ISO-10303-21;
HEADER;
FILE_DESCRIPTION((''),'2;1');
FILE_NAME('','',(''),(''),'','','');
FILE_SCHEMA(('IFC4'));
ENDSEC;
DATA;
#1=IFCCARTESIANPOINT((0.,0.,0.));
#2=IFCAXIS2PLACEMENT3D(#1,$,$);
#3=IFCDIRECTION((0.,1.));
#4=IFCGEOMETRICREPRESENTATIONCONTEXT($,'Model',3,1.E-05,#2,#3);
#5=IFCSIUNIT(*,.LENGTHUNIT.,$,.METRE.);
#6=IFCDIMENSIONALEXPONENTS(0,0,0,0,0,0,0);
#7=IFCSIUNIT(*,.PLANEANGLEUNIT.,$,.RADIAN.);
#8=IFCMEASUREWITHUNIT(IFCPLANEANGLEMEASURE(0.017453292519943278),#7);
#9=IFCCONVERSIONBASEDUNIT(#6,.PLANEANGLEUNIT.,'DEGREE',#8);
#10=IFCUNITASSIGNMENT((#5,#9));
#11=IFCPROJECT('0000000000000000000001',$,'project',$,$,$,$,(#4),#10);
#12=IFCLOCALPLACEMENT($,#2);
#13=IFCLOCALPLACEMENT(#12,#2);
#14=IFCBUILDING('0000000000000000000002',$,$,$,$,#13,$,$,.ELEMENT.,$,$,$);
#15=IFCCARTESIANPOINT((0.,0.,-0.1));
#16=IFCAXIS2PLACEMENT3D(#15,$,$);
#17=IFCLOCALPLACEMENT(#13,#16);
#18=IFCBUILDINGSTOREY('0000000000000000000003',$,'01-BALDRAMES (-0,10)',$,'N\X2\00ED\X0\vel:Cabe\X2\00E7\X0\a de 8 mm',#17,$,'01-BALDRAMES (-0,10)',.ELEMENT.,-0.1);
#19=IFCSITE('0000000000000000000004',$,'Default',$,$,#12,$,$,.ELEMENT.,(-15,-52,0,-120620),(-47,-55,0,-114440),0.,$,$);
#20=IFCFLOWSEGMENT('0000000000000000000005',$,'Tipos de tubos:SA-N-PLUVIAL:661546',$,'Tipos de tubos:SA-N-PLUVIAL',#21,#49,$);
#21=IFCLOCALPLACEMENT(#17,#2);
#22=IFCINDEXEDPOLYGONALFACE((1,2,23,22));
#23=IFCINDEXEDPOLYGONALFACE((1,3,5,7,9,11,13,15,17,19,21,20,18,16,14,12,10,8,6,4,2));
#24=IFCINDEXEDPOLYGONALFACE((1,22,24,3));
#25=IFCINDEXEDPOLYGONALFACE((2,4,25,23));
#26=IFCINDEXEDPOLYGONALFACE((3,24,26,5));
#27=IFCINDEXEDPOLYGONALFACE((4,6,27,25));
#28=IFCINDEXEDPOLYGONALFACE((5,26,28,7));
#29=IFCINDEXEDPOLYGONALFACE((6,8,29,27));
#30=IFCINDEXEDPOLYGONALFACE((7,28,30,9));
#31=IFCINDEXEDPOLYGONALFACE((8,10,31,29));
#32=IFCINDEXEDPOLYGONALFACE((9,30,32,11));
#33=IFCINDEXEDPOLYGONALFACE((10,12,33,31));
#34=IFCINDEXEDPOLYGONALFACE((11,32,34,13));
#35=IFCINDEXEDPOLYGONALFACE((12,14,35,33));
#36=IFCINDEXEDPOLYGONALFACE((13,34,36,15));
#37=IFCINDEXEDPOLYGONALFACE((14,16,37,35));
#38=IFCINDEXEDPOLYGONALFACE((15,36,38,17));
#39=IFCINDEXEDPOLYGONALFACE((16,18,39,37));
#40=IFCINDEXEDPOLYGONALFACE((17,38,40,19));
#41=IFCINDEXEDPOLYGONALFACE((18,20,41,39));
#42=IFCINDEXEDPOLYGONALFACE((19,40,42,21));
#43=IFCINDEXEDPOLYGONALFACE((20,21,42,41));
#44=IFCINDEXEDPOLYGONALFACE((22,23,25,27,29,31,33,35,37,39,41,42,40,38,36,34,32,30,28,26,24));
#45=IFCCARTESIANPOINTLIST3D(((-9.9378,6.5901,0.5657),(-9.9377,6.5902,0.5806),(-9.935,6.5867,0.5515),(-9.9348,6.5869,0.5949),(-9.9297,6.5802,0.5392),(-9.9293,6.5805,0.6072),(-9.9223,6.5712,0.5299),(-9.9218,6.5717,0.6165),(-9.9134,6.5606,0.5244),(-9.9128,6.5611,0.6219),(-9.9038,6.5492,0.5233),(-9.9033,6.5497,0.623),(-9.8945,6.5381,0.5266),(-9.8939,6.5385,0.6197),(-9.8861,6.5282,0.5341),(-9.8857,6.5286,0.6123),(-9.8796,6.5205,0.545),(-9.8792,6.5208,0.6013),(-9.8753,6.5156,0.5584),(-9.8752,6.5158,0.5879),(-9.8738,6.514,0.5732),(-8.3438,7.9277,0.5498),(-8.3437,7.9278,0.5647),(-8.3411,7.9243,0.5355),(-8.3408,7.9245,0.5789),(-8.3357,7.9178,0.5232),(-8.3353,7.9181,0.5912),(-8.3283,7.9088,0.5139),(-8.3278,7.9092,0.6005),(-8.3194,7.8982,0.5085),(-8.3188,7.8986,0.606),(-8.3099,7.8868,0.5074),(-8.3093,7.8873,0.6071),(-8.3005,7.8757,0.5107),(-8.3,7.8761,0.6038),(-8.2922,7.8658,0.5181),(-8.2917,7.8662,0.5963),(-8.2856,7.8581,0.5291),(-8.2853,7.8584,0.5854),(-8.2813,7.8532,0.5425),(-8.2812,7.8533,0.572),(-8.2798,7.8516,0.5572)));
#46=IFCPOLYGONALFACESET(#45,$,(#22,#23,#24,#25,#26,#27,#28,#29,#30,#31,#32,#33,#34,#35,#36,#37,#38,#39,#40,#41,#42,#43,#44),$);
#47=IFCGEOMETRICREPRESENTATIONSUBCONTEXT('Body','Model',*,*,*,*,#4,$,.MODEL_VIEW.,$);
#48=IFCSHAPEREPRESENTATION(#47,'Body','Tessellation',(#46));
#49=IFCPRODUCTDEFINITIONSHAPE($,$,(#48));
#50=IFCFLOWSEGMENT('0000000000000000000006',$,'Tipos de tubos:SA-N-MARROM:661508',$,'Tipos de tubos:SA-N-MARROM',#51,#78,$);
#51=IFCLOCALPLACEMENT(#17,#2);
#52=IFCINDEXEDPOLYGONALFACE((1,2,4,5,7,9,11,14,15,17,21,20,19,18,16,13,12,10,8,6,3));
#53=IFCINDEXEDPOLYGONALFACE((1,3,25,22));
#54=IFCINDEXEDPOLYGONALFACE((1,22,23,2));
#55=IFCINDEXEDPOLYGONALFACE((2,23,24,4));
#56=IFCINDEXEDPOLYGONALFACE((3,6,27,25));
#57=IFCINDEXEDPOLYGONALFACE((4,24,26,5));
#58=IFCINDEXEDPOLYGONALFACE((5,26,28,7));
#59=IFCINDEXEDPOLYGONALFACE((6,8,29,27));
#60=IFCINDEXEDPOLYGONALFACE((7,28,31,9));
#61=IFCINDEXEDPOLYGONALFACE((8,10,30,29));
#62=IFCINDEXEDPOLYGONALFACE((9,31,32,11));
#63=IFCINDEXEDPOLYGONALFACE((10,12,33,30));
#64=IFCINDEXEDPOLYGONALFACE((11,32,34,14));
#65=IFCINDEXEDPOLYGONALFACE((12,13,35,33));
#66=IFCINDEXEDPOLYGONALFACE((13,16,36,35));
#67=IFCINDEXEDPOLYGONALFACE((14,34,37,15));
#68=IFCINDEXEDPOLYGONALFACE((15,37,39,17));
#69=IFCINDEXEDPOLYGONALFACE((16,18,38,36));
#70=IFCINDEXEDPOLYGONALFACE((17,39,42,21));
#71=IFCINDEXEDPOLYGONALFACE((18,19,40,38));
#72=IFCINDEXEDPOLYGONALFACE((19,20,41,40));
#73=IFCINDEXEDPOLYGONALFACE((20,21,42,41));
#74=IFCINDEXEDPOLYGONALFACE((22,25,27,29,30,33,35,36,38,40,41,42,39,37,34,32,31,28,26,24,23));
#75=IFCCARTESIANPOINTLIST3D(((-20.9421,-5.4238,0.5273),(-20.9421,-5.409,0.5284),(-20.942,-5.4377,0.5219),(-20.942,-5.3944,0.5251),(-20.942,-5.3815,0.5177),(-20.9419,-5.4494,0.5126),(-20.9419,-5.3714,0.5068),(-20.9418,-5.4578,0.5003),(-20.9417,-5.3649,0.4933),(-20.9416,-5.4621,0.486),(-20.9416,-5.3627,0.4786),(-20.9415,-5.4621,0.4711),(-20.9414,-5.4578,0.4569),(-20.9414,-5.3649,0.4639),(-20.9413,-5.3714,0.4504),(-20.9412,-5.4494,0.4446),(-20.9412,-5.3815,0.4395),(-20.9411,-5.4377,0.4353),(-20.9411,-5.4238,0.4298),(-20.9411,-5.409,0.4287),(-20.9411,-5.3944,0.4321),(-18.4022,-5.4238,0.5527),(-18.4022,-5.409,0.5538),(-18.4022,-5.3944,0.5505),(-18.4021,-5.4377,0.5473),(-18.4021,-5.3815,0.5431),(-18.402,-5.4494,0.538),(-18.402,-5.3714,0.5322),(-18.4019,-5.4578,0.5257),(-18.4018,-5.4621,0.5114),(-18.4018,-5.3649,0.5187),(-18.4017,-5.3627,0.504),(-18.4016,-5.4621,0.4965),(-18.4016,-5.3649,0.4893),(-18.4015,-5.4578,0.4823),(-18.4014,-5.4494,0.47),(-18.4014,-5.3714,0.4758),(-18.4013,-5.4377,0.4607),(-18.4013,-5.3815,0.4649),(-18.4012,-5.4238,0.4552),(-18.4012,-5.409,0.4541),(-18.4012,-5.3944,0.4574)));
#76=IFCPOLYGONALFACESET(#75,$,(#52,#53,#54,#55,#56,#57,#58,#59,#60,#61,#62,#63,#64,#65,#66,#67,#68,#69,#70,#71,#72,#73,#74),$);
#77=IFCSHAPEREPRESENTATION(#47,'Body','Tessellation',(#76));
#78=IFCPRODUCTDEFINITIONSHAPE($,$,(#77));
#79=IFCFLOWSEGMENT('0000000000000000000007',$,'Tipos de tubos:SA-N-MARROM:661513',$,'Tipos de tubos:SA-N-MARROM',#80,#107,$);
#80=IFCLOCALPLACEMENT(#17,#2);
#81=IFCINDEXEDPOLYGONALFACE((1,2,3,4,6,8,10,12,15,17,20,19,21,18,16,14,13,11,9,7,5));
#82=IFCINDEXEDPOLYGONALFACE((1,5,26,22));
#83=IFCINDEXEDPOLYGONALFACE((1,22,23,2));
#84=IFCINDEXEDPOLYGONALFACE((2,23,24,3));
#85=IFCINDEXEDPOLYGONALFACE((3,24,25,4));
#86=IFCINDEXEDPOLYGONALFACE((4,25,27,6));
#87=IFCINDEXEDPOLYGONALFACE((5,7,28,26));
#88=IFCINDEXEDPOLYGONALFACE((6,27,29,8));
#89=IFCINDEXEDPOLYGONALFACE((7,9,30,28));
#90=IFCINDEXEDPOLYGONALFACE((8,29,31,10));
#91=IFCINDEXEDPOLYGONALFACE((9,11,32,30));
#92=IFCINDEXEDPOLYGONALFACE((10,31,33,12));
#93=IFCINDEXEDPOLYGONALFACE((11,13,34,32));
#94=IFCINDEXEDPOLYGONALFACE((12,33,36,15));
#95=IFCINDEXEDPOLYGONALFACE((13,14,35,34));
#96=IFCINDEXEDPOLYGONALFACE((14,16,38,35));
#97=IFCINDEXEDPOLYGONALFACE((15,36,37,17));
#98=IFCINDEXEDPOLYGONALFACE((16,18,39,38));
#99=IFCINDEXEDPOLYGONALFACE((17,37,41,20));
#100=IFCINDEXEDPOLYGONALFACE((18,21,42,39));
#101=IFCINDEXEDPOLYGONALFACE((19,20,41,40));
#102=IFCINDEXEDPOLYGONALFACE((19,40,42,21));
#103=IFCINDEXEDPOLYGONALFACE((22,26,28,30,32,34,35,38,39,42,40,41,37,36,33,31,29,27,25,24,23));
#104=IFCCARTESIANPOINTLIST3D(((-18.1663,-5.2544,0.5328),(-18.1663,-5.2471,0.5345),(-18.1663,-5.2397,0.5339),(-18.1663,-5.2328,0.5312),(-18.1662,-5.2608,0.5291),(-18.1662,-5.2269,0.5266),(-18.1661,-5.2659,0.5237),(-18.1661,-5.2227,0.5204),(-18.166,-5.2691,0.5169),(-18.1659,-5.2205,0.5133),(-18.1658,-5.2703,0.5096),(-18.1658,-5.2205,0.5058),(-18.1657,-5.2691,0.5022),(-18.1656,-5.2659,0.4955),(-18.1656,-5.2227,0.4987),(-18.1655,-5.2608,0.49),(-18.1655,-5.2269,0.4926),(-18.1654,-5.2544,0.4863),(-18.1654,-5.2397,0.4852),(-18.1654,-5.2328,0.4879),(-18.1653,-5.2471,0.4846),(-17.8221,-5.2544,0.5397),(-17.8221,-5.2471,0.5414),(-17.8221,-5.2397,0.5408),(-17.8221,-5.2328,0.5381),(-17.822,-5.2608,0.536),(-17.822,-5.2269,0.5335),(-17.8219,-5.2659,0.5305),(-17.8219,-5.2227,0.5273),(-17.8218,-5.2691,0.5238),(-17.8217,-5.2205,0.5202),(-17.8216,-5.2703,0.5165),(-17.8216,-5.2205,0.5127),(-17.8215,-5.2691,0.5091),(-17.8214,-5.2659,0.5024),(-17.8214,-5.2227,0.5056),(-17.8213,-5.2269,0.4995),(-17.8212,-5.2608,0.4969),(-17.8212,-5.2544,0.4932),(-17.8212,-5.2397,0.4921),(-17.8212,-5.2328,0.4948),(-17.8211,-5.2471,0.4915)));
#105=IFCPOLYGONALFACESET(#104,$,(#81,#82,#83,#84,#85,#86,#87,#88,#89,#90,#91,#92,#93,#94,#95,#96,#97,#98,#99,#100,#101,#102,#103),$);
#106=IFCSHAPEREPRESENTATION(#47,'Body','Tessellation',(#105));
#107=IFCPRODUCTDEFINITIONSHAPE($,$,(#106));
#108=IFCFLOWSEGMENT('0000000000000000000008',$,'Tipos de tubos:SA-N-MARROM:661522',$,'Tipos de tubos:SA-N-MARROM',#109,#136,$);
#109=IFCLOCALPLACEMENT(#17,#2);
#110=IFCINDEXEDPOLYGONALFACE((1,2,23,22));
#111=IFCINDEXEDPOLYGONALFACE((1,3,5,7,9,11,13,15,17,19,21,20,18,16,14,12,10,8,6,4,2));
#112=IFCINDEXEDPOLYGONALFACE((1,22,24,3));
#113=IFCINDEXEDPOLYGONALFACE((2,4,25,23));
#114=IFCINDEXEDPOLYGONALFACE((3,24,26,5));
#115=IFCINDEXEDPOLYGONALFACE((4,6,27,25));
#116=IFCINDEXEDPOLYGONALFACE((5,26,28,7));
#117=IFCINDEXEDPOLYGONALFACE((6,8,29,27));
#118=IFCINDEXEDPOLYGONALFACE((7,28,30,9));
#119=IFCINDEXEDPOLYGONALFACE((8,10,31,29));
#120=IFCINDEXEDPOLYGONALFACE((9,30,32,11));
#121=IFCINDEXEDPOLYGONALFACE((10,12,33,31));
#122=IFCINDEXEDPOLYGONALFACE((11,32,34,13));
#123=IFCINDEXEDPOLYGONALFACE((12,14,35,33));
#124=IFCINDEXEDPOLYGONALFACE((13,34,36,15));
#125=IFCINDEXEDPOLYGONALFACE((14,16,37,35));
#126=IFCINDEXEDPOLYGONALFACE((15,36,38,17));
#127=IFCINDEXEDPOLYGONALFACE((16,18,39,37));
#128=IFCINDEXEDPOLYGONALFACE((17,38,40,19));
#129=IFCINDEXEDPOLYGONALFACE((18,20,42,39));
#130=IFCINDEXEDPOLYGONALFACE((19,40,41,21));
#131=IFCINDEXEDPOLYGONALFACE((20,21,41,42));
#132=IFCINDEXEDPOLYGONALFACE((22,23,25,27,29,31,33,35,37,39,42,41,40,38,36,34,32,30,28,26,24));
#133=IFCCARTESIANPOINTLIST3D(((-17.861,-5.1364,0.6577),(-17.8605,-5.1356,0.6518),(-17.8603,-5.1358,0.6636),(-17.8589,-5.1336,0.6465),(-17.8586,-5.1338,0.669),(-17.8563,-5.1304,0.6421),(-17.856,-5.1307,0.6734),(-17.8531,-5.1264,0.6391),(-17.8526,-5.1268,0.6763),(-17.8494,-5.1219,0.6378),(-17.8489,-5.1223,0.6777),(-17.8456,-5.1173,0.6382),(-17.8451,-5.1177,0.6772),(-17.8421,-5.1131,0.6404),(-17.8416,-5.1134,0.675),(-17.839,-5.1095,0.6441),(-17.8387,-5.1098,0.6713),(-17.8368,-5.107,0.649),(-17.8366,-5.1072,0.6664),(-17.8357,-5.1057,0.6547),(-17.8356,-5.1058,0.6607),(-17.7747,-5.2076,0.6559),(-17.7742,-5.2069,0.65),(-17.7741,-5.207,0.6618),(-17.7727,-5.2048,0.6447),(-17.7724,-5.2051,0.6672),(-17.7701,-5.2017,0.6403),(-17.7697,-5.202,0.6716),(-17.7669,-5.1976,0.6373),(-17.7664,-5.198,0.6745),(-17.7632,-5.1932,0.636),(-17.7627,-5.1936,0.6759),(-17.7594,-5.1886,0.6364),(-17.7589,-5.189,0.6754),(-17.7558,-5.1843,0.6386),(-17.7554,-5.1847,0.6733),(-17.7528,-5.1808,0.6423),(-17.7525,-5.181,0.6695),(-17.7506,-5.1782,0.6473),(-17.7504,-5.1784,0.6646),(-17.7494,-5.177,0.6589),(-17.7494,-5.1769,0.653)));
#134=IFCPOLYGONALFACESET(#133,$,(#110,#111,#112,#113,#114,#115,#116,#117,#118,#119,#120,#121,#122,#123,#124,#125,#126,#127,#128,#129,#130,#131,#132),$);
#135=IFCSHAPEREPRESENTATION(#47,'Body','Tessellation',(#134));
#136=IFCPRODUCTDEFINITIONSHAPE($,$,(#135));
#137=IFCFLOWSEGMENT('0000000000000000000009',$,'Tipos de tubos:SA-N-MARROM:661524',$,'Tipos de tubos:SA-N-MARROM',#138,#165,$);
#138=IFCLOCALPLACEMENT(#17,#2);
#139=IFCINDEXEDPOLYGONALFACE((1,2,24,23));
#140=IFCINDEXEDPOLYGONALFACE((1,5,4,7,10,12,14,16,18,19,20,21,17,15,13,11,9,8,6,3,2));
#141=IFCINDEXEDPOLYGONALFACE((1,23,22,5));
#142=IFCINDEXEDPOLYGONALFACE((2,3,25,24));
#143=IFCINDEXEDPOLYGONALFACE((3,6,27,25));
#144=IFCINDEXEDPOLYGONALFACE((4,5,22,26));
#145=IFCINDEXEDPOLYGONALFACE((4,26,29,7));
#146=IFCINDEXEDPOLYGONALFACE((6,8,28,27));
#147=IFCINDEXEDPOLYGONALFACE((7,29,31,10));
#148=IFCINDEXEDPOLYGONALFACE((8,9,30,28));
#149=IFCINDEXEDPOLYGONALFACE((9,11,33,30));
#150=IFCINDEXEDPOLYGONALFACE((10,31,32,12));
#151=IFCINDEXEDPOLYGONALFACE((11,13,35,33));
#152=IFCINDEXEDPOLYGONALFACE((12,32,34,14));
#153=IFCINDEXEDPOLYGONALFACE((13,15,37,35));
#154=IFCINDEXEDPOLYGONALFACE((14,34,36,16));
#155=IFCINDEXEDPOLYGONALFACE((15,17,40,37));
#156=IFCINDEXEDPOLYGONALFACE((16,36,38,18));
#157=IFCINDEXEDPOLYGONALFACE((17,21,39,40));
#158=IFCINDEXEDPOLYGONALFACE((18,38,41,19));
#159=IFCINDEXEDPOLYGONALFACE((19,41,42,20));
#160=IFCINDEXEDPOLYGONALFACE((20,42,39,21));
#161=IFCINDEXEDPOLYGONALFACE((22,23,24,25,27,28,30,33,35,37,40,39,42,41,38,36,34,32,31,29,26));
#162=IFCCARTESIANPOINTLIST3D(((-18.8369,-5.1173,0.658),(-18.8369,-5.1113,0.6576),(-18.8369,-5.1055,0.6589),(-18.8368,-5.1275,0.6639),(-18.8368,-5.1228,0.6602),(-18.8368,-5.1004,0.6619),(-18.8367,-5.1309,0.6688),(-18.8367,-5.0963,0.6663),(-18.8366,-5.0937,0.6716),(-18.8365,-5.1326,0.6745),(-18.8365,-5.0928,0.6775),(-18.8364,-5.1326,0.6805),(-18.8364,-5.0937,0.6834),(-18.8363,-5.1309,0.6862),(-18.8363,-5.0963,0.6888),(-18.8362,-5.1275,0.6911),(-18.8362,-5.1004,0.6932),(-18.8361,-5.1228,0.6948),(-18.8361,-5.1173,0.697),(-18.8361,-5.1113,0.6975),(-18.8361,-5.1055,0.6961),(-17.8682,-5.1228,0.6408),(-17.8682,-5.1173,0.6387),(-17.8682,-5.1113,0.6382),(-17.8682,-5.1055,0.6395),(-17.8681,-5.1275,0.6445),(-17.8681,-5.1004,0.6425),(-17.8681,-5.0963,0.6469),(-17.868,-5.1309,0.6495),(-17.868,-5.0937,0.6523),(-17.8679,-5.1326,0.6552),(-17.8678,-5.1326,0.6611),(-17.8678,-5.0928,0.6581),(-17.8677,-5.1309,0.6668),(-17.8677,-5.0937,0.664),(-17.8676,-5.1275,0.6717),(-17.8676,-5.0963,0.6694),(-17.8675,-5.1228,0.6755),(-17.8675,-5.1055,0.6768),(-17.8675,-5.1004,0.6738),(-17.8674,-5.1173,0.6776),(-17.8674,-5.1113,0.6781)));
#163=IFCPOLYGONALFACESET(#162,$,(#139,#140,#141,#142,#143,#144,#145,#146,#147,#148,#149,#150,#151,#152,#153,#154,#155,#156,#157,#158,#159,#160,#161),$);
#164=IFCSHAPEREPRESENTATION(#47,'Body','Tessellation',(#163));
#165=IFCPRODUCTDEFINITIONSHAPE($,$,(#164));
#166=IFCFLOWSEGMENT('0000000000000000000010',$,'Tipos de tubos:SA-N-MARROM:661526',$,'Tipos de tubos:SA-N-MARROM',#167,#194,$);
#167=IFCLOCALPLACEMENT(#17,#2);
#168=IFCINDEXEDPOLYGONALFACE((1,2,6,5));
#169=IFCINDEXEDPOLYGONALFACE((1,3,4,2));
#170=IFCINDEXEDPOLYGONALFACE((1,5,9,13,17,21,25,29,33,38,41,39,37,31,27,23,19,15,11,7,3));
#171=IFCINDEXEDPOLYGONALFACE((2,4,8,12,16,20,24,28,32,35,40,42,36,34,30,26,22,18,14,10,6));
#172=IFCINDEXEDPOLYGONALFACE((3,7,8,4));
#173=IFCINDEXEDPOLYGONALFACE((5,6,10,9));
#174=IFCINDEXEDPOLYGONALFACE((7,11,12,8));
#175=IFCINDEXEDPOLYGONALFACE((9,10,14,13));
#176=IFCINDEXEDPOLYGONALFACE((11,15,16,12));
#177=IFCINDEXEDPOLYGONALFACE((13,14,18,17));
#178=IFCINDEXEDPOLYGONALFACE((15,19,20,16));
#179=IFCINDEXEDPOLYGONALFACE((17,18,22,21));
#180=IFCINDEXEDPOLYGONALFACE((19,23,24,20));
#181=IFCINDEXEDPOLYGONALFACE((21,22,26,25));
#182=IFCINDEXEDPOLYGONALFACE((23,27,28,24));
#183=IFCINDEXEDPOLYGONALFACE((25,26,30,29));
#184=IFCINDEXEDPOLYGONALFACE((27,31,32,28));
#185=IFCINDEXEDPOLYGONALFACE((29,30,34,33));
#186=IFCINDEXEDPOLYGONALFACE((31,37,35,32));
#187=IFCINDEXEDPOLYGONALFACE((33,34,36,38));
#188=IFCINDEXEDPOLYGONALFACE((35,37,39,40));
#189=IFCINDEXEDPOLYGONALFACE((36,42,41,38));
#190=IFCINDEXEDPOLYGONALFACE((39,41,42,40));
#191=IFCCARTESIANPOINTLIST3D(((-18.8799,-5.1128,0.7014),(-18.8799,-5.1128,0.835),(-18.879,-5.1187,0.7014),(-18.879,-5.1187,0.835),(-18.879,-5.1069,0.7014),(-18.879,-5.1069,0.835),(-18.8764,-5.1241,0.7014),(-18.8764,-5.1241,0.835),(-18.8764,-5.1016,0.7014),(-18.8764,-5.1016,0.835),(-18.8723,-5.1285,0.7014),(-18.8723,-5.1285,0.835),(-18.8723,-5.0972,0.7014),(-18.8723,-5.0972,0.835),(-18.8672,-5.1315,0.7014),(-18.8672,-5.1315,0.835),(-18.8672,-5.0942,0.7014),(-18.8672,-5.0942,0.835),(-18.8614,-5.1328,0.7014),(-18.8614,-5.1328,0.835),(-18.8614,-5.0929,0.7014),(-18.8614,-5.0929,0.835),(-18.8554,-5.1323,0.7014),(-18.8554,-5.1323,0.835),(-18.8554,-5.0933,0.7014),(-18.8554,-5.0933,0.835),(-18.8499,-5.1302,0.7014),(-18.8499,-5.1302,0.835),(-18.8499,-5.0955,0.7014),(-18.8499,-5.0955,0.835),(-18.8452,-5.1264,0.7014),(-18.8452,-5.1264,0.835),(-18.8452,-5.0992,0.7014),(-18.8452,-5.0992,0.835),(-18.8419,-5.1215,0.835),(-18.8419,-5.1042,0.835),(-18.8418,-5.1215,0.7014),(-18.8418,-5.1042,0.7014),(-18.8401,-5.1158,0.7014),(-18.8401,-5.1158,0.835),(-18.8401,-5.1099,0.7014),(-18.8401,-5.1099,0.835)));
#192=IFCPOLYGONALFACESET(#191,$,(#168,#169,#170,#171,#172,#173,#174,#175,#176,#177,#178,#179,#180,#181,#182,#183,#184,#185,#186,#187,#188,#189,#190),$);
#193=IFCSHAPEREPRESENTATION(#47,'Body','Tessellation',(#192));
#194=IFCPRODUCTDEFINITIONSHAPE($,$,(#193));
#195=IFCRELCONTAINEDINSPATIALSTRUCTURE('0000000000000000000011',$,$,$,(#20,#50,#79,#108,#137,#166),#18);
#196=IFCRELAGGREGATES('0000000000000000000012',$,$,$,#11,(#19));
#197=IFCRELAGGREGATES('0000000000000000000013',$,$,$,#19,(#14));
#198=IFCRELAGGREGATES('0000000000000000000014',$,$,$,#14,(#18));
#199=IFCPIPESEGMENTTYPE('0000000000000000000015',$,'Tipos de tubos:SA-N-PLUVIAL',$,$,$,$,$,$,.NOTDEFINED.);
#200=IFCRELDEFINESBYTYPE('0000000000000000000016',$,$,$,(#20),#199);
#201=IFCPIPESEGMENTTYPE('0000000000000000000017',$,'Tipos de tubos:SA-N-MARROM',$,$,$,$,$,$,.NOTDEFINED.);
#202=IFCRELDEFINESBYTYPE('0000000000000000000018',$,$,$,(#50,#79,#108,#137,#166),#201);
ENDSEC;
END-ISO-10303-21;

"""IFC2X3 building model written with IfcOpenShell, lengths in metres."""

from ifc_helpers import new_model, entity, si_unit, converted_unit, direction, frame, frame_2d, origin, origin_2d_with_axis, place, context, subcontext, project, spatial, circle, extrude, type_object, element, save


model = new_model("IFC2X3")

# Units and contexts
model_context = context("Model", 3, precision=1e-05, world=origin(), true_north=direction((0.0, 1.0)))
body_context = subcontext(model_context, "Body", "Model", "MODEL_VIEW")
ifc_project = project(units=[si_unit("LENGTHUNIT", "METRE"), converted_unit("PLANEANGLEUNIT", "DEGREE", entity("IfcPlaneAngleMeasure", 0.017453292519943278), si_unit("PLANEANGLEUNIT", "RADIAN"), dimensions=[0, 0, 0, 0, 0, 0, 0])], contexts=[model_context])

# Site, building, storey
site_placement = place(None, origin())
site = spatial("IfcSite", under=ifc_project, at=site_placement, Name="Default", CompositionType="ELEMENT", RefLatitude=(-15, -52, 0, -120620), RefLongitude=(-47, -55, 0, -114440), RefElevation=0.0)
building_placement = place(site_placement, origin())
building = spatial("IfcBuilding", under=site, at=building_placement, CompositionType="ELEMENT")
storey_placement = place(building_placement, frame((0.0, 0.0, -0.1)))
storey = spatial("IfcBuildingStorey", under=building, at=storey_placement, Name="01-BALDRAMES (-0,10)", ObjectType="Nível:Cabeça de 8 mm", LongName="01-BALDRAMES (-0,10)", CompositionType="ELEMENT", Elevation=-0.1)

# Flow segments
pipe_segment_type_1 = type_object("IfcPipeSegmentType", Name="Tipos de tubos:SA-N-PLUVIAL", PredefinedType="NOTDEFINED")
flow_segment_1_placement = place(storey_placement, origin())
element("IfcFlowSegment", 1, at=flow_segment_1_placement, inside=storey, type_object=pipe_segment_type_1, Name="Tipos de tubos:SA-N-PLUVIAL:661546", ObjectType="Tipos de tubos:SA-N-PLUVIAL", context=body_context, shape_type="SweptSolid", body=[
    extrude(circle(Radius=0.05, at=frame_2d((0.0, 0.0), x_axis=(1.0, 0.0))), frame((-8.312, 7.8899, 0.5572), z_axis=(-0.766006, -0.642788, 0.00766), x_axis=(0.642807, -0.766028, 0.0)), (0.0, 0.0, 1.0), 2.0809),
])
pipe_segment_type_2 = type_object("IfcPipeSegmentType", Name="Tipos de tubos:SA-N-MARROM", PredefinedType="NOTDEFINED")
flow_segment_2_placement = place(storey_placement, origin())
element("IfcFlowSegment", 2, at=flow_segment_2_placement, inside=storey, type_object=pipe_segment_type_2, Name="Tipos de tubos:SA-N-MARROM:661508", ObjectType="Tipos de tubos:SA-N-MARROM", context=body_context, shape_type="SweptSolid", body=[
    extrude(circle(Radius=0.05, at=frame_2d((0.0, 0.0), x_axis=(1.0, 0.0))), frame((-20.9416, -5.4127, 0.4786), z_axis=(0.99995, 0.000001, 0.01), x_axis=(-0.000001, 1.0, 0.0)), (0.0, 0.0, 1.0), 2.54),
])
flow_segment_3_placement = place(storey_placement, origin())
element("IfcFlowSegment", 3, at=flow_segment_3_placement, inside=storey, type_object=pipe_segment_type_2, Name="Tipos de tubos:SA-N-MARROM:661513", ObjectType="Tipos de tubos:SA-N-MARROM", context=body_context, shape_type="SweptSolid", body=[
    extrude(circle(Radius=0.025, at=origin_2d_with_axis()), frame((-18.1658, -5.2453, 0.5096), z_axis=(0.9998, 0.000001, 0.019996), x_axis=(0.000001, -1.0, 0.0)), (0.0, 0.0, 1.0), 0.3443),
])
flow_segment_4_placement = place(storey_placement, origin())
element("IfcFlowSegment", 4, at=flow_segment_4_placement, inside=storey, type_object=pipe_segment_type_2, Name="Tipos de tubos:SA-N-MARROM:661522", ObjectType="Tipos de tubos:SA-N-MARROM", context=body_context, shape_type="SweptSolid", body=[
    extrude(circle(Radius=0.02, at=frame_2d((0.0, 0.0), x_axis=(1.0, 0.0))), frame((-17.762, -5.1922, 0.6559), z_axis=(-0.770828, 0.636844, 0.015942), x_axis=(-0.636925, -0.770926, 0.0)), (0.0, 0.0, 1.0), 0.1118),
])
flow_segment_5_placement = place(storey_placement, origin())
element("IfcFlowSegment", 5, at=flow_segment_5_placement, inside=storey, type_object=pipe_segment_type_2, Name="Tipos de tubos:SA-N-MARROM:661524", ObjectType="Tipos de tubos:SA-N-MARROM", context=body_context, shape_type="SweptSolid", body=[
    extrude(circle(Radius=0.02, at=origin_2d_with_axis()), frame((-17.8678, -5.1128, 0.6581), z_axis=(-0.9998, -0.000001, 0.019996), x_axis=(-0.000001, 1.0, 0.0)), (0.0, 0.0, 1.0), 0.9688),
])
flow_segment_6_placement = place(storey_placement, origin())
element("IfcFlowSegment", 6, at=flow_segment_6_placement, inside=storey, type_object=pipe_segment_type_2, Name="Tipos de tubos:SA-N-MARROM:661526", ObjectType="Tipos de tubos:SA-N-MARROM", context=body_context, shape_type="SweptSolid", body=[
    extrude(circle(Radius=0.02, at=origin_2d_with_axis()), frame((-18.8599, -5.1128, 0.7014), z_axis=(-0.000135, 0.000034, 1.0), x_axis=(-1.0, 0.0, -0.000135)), (0.0, 0.0, 1.0), 0.1336),
])

save(model, "model.ifc")
